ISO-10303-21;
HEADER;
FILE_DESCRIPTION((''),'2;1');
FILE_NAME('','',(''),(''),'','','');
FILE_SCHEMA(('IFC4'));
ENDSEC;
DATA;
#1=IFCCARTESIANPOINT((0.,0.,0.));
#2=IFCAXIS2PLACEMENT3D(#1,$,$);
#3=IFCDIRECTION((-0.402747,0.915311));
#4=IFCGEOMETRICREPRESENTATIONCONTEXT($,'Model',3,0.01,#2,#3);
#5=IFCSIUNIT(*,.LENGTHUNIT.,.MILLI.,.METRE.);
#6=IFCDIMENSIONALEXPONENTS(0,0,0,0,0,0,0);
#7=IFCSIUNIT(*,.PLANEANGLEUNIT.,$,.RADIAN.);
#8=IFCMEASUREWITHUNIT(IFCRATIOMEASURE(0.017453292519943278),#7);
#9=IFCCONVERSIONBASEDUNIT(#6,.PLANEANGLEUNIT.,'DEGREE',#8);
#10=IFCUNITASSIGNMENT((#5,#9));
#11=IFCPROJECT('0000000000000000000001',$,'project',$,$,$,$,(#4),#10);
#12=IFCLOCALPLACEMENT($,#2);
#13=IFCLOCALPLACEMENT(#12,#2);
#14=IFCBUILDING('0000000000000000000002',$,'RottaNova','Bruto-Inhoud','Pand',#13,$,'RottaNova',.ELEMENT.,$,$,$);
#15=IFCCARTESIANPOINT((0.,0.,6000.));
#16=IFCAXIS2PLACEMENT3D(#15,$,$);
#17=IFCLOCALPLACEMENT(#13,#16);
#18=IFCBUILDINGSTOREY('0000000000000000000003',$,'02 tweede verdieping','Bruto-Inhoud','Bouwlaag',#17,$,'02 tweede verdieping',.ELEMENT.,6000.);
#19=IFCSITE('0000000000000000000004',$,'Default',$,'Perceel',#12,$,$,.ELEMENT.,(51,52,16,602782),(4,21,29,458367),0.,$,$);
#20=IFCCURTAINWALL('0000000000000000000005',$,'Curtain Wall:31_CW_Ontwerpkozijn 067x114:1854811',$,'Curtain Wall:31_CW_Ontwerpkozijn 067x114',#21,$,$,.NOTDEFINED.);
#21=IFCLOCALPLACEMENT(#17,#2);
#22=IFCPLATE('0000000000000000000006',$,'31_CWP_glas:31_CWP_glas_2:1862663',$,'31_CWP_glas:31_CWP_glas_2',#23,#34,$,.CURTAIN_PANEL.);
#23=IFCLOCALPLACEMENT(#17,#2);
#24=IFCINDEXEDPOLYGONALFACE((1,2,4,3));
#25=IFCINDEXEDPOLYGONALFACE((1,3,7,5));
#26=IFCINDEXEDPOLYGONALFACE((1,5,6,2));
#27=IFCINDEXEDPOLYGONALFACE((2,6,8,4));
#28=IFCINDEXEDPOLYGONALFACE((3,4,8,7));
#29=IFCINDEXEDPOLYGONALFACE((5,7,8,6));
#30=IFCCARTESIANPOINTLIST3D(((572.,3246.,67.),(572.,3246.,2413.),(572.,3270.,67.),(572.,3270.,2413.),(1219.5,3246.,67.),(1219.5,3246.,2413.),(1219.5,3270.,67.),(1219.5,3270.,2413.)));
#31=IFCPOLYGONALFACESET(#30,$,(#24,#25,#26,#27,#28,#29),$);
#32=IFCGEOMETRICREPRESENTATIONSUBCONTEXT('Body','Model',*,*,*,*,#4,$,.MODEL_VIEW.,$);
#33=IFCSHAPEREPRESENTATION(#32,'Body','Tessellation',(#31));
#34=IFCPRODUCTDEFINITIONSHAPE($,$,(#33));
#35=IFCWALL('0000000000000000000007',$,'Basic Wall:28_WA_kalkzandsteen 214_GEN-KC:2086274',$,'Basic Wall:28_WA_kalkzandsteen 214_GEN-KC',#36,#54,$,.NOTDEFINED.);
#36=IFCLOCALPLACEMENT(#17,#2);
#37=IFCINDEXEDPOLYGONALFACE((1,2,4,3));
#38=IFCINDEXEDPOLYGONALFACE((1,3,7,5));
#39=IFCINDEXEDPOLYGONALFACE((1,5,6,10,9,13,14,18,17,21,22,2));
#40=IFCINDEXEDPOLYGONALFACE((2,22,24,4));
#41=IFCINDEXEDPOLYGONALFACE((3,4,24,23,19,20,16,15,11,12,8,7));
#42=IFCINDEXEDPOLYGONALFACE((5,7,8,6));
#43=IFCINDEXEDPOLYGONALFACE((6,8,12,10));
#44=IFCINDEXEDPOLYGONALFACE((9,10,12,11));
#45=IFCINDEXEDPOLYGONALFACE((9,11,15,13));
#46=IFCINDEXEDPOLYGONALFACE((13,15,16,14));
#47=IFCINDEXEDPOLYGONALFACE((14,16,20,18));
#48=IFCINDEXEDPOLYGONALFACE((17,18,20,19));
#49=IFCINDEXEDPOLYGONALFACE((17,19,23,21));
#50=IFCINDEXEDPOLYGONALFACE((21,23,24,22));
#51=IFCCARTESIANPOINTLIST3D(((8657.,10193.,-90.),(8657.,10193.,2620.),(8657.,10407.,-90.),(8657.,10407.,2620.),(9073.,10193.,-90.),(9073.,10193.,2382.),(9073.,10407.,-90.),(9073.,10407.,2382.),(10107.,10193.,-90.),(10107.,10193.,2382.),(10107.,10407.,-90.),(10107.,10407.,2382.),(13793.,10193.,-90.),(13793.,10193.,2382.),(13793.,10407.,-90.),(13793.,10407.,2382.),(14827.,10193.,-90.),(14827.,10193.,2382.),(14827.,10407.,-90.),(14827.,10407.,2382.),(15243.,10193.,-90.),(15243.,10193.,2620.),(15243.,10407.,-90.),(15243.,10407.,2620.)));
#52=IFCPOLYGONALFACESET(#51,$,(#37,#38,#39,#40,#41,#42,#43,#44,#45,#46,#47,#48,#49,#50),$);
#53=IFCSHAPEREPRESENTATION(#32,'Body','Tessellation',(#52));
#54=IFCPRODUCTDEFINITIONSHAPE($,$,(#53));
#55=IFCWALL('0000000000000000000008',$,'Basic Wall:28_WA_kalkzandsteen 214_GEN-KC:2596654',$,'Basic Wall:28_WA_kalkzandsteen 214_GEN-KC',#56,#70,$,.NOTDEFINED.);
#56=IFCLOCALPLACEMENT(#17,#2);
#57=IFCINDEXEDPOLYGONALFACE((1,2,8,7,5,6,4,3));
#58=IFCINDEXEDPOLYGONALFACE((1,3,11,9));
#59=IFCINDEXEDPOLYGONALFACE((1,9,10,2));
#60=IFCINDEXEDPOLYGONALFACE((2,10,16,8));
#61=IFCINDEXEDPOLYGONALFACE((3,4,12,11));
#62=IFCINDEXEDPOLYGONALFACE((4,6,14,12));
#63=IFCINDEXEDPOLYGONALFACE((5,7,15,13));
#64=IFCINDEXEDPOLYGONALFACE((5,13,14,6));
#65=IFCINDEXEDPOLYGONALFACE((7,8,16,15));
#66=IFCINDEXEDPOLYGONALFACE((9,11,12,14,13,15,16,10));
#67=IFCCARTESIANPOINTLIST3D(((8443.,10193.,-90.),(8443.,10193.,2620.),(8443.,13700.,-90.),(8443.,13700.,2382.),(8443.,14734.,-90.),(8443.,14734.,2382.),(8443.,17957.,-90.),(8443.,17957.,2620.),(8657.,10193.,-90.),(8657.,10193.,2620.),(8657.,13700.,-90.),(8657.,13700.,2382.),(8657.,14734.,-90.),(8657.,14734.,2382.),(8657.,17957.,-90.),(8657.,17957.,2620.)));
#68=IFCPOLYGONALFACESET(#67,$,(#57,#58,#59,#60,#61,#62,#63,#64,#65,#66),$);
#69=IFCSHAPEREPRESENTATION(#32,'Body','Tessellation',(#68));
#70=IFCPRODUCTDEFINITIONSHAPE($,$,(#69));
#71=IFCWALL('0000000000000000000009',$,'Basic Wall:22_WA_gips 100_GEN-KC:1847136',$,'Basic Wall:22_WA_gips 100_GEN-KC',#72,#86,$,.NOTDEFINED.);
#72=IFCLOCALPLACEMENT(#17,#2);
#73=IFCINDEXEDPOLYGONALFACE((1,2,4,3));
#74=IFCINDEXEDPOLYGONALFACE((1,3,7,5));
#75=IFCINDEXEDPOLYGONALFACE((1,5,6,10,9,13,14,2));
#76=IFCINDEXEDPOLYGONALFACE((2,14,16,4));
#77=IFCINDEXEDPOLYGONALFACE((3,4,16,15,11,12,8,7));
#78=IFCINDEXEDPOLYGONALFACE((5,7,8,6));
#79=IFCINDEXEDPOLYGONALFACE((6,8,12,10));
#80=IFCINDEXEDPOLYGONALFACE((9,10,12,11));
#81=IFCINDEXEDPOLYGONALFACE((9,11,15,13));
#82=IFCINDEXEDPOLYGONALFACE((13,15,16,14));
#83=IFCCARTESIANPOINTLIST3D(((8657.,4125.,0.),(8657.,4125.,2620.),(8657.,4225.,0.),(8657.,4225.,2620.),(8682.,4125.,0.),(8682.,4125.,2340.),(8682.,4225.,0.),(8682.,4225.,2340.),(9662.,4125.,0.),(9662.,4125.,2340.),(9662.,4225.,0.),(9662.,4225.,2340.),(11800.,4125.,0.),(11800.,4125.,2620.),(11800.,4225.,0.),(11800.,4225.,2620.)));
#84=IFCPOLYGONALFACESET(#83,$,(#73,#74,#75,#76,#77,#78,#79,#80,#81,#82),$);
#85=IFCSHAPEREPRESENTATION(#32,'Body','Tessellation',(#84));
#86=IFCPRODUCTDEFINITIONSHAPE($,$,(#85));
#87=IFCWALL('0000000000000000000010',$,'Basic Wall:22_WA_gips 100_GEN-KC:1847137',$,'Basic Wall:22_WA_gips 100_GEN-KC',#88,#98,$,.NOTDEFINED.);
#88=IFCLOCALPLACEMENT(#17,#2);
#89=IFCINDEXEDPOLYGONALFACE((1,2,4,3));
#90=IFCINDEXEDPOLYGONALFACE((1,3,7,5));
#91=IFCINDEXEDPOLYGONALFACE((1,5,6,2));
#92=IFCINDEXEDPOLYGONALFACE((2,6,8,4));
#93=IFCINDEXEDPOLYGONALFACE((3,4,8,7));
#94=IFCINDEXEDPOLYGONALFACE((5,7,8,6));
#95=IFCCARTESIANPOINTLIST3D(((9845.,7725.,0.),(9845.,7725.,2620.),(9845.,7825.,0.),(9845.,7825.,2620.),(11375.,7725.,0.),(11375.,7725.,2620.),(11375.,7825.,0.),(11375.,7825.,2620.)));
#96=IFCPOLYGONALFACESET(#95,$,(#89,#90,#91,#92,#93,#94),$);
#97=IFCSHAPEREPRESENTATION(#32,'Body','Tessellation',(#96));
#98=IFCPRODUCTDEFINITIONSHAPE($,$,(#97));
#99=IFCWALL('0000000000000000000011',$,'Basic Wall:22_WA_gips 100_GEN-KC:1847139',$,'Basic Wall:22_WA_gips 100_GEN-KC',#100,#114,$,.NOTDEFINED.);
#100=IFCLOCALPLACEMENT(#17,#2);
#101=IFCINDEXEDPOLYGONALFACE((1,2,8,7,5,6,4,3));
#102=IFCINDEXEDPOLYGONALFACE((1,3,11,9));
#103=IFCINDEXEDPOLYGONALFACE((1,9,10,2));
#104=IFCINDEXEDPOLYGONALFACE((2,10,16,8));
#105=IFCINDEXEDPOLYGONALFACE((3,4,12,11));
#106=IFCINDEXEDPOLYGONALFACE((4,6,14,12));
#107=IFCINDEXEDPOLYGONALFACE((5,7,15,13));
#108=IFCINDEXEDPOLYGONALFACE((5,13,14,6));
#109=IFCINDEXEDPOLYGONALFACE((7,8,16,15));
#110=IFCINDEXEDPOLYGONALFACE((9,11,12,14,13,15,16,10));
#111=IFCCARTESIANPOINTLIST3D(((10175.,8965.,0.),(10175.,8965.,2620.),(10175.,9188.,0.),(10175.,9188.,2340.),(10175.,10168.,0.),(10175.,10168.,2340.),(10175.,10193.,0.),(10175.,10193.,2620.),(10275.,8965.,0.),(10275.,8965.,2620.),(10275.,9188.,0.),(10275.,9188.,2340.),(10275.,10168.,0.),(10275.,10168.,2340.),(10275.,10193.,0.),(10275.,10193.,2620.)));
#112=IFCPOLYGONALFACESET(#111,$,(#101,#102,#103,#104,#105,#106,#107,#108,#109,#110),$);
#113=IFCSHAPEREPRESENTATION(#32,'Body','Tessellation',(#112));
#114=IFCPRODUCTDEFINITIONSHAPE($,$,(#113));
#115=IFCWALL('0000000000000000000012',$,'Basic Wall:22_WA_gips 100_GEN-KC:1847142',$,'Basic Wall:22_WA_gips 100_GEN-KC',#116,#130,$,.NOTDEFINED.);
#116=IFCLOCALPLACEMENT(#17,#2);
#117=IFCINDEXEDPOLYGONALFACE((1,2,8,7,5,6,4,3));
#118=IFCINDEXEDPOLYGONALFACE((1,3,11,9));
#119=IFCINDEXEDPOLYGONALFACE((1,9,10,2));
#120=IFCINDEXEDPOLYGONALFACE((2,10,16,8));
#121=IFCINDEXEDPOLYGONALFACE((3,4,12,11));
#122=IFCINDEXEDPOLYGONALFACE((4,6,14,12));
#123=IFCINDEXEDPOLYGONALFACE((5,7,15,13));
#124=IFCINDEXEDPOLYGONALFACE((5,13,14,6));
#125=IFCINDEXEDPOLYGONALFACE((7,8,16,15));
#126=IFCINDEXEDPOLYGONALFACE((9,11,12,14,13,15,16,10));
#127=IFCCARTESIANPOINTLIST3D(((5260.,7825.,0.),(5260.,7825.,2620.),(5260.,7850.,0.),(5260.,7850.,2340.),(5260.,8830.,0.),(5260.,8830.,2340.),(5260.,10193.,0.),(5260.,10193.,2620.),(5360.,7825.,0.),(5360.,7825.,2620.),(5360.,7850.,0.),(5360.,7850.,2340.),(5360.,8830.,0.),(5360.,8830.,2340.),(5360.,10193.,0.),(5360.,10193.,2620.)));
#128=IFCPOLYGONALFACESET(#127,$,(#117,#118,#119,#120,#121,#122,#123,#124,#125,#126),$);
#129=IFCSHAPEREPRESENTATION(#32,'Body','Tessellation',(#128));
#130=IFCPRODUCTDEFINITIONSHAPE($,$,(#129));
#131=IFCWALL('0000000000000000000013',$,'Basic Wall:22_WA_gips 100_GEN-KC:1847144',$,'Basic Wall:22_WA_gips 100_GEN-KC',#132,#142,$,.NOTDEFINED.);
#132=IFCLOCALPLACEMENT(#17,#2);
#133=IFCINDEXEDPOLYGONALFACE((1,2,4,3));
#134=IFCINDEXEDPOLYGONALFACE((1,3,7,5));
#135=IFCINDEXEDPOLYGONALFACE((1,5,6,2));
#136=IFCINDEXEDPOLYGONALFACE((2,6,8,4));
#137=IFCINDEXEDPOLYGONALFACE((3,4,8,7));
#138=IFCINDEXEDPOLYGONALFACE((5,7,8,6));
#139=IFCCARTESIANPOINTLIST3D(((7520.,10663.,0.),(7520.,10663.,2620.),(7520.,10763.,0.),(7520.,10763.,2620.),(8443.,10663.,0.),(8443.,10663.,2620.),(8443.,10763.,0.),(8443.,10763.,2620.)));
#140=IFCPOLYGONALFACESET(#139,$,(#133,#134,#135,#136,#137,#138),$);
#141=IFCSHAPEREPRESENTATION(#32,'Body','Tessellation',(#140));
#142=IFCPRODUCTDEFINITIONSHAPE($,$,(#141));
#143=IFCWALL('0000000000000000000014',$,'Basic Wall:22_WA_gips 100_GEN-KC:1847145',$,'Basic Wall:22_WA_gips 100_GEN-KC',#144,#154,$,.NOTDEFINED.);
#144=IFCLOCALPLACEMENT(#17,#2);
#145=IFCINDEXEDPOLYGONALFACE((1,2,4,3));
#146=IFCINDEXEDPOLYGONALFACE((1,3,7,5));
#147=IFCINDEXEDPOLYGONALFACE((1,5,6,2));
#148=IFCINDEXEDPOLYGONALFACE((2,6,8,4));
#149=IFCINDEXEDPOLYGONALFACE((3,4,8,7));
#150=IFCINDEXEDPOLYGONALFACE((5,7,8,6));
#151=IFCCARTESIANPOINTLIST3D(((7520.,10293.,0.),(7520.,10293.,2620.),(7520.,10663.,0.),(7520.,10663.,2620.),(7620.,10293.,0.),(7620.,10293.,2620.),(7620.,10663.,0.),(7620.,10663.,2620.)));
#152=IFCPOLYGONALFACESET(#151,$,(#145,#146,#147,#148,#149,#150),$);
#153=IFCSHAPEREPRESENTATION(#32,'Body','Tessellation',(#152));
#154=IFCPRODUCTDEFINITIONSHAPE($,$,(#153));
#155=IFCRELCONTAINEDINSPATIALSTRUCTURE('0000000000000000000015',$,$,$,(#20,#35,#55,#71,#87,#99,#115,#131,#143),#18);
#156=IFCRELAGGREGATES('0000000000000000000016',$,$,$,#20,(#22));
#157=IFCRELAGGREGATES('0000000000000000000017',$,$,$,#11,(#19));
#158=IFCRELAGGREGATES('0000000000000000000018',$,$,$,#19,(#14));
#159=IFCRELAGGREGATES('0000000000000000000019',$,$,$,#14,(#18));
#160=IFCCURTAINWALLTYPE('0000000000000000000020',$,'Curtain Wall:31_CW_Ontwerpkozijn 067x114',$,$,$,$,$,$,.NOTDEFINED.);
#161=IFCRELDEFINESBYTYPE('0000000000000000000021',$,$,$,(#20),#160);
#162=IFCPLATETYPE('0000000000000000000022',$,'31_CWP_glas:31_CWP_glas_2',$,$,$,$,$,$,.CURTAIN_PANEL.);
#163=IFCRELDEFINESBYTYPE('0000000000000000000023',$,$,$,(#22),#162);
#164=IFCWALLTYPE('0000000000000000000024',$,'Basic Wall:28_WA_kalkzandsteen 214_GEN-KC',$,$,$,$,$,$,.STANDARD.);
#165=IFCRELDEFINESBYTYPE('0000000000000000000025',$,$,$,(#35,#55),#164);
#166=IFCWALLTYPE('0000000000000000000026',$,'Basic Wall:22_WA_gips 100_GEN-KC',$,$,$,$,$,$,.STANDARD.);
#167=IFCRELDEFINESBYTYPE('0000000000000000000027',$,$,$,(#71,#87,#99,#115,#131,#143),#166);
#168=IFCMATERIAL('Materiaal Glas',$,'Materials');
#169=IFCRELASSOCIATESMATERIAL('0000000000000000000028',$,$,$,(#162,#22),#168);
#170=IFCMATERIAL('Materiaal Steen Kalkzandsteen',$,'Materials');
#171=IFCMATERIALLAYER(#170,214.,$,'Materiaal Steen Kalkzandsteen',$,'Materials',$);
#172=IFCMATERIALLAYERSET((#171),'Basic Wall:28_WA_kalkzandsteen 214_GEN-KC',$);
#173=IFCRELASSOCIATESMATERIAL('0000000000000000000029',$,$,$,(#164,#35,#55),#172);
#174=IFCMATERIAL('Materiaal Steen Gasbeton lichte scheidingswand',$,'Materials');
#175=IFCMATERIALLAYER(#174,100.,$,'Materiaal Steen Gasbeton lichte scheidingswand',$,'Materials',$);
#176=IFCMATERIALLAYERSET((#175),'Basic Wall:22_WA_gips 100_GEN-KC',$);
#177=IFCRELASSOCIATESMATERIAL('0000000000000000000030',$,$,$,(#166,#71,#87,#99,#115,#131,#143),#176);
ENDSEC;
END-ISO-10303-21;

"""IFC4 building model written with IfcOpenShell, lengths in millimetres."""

from ifc_helpers import new_model, entity, si_unit, converted_unit, direction, frame, frame_2d, origin, place, context, subcontext, project, spatial, rectangle, extrude, source, transform, mapped, material, layer, layer_set, type_object, type_shapes, element, aggregate, save


model = new_model("IFC4")

# Units and contexts
model_context = context("Model", 3, precision=0.01, world=origin(), true_north=direction((-0.402747, 0.915311)))
body_context = subcontext(model_context, "Body", "Model", "MODEL_VIEW")
ifc_project = project(units=[si_unit("LENGTHUNIT", "METRE", prefix="MILLI"), converted_unit("PLANEANGLEUNIT", "DEGREE", entity("IfcRatioMeasure", 0.017453292519943278), si_unit("PLANEANGLEUNIT", "RADIAN"), dimensions=[0, 0, 0, 0, 0, 0, 0])], contexts=[model_context])

# Site, building, storey
site_placement = place(None, origin())
site = spatial("IfcSite", under=ifc_project, at=site_placement, Name="Default", ObjectType="Perceel", CompositionType="ELEMENT", RefLatitude=(51, 52, 16, 602782), RefLongitude=(4, 21, 29, 458367), RefElevation=0.0)
building_placement = place(site_placement, origin())
building = spatial("IfcBuilding", under=site, at=building_placement, Name="RottaNova", Description="Bruto-Inhoud", ObjectType="Pand", LongName="RottaNova", CompositionType="ELEMENT")
storey_placement = place(building_placement, frame((0.0, 0.0, 6000.0)))
storey = spatial("IfcBuildingStorey", under=building, at=storey_placement, Name="02 tweede verdieping", Description="Bruto-Inhoud", ObjectType="Bouwlaag", LongName="02 tweede verdieping", CompositionType="ELEMENT", Elevation=6000.0)

# Shared definitions
curtain_wall_type = type_object("IfcCurtainWallType", Name="Curtain Wall:31_CW_Ontwerpkozijn 067x114", PredefinedType="NOTDEFINED")

# Curtain wall
curtain_wall_1_placement = place(storey_placement, frame((0.0, 0.0, -6000.0)))
curtain_wall_1 = element("IfcCurtainWall", 1, at=curtain_wall_1_placement, inside=storey, type_object=curtain_wall_type, Name="Curtain Wall:31_CW_Ontwerpkozijn 067x114:1854811", ObjectType="Curtain Wall:31_CW_Ontwerpkozijn 067x114", PredefinedType="NOTDEFINED")

# Plate
ifc_material_1 = material(Name="Materiaal Glas", Category="Materials")
plate_type_1 = type_object("IfcPlateType", Name="31_CWP_glas:31_CWP_glas_2", PredefinedType="CURTAIN_PANEL", material=ifc_material_1)
shared_shape_1 = source(origin(), body_context, "Body", "SweptSolid", [
    extrude(rectangle(XDim=24.0, YDim=647.5, at=frame_2d((0.0, 0.0), x_axis=(1.0, 0.0))), frame((323.8, 12.0, 0.0), z_axis=(0.0, 0.0, 1.0), x_axis=(0.0, 1.0, 0.0)), (0.0, 0.0, 1.0), 2346.0),
])
type_shapes(plate_type_1, [shared_shape_1])
plate_1_placement = place(curtain_wall_1_placement, frame((1219.5, 3270.0, 6067.0), z_axis=(0.0, 0.0, 1.0), x_axis=(-1.0, 0.0, 0.0)))
plate_1 = element("IfcPlate", 2, at=plate_1_placement, type_object=plate_type_1, material=ifc_material_1, Name="31_CWP_glas:31_CWP_glas_2:1862663", ObjectType="31_CWP_glas:31_CWP_glas_2", PredefinedType="CURTAIN_PANEL", context=body_context, shape_type="MappedRepresentation", body=[
    mapped(shared_shape_1, transform((0.0, 0.0, 0.0), scale=1.0)),
])
aggregate(curtain_wall_1, [plate_1])

# Wall, openings
ifc_material_2 = material(Name="Materiaal Steen Kalkzandsteen", Category="Materials")
ifc_layer_1 = layer(ifc_material_2, 214.0, Name="Materiaal Steen Kalkzandsteen", Category="Materials")
ifc_layer_set_1 = layer_set([ifc_layer_1], Name="Basic Wall:28_WA_kalkzandsteen 214_GEN-KC")
wall_type_1 = type_object("IfcWallType", Name="Basic Wall:28_WA_kalkzandsteen 214_GEN-KC", PredefinedType="STANDARD", material=ifc_layer_set_1)
wall_1_placement = place(storey_placement, frame((8657.0, 10300.0, -90.0)))
wall_1 = element("IfcWall", 3, at=wall_1_placement, inside=storey, type_object=wall_type_1, material=ifc_layer_set_1, Name="Basic Wall:28_WA_kalkzandsteen 214_GEN-KC:2086274", ObjectType="Basic Wall:28_WA_kalkzandsteen 214_GEN-KC", PredefinedType="NOTDEFINED", context=body_context, shape_type="SweptSolid", body=[
    extrude(rectangle(XDim=6586.0, YDim=214.0, at=frame_2d((3293.0, 0.0), x_axis=(-1.0, 0.0))), origin(), (0.0, 0.0, 1.0), 2710.0),
])
opening_1_placement = place(wall_1_placement, frame((5136.0, -107.0, 0.0)))
element("IfcOpeningElement", 4, at=opening_1_placement, cuts=wall_1, PredefinedType="OPENING", context=body_context, shape_type="SweptSolid", body=[
    extrude(rectangle(XDim=2472.0, YDim=1034.0, at=frame_2d((0.0, 0.0), x_axis=(1.0, 0.0))), frame((517.0, 0.0, 1236.0), z_axis=(0.0, 1.0, 0.0), x_axis=(0.0, 0.0, -1.0)), (0.0, 0.0, 1.0), 214.0),
])
opening_2_placement = place(wall_1_placement, frame((416.0, -107.0, 0.0)))
element("IfcOpeningElement", 5, at=opening_2_placement, cuts=wall_1, PredefinedType="OPENING", context=body_context, shape_type="SweptSolid", body=[
    extrude(rectangle(XDim=2472.0, YDim=1034.0, at=frame_2d((0.0, 0.0), x_axis=(1.0, 0.0))), frame((517.0, 0.0, 1236.0), z_axis=(0.0, 1.0, 0.0), x_axis=(0.0, 0.0, -1.0)), (0.0, 0.0, 1.0), 214.0),
])

# Walls, openings
wall_2_placement = place(storey_placement, frame((8550.0, 10193.0, -90.0), z_axis=(0.0, 0.0, 1.0), x_axis=(0.0, 1.0, 0.0)))
wall_2 = element("IfcWall", 6, at=wall_2_placement, inside=storey, type_object=wall_type_1, material=ifc_layer_set_1, Name="Basic Wall:28_WA_kalkzandsteen 214_GEN-KC:2596654", ObjectType="Basic Wall:28_WA_kalkzandsteen 214_GEN-KC", PredefinedType="NOTDEFINED", context=body_context, shape_type="SweptSolid", body=[
    extrude(rectangle(XDim=7764.0, YDim=214.0, at=frame_2d((3882.0, 0.0), x_axis=(1.0, 0.0))), origin(), (0.0, 0.0, 1.0), 2710.0),
])
opening_3_placement = place(wall_2_placement, frame((3507.0, 107.0, 0.0)))
element("IfcOpeningElement", 7, at=opening_3_placement, cuts=wall_2, PredefinedType="OPENING", context=body_context, shape_type="SweptSolid", body=[
    extrude(rectangle(XDim=2472.0, YDim=1034.0, at=frame_2d((0.0, 0.0), x_axis=(1.0, 0.0))), frame((517.0, -214.0, 1236.0), z_axis=(0.0, 1.0, 0.0), x_axis=(0.0, 0.0, -1.0)), (0.0, 0.0, 1.0), 214.0),
])
ifc_material_3 = material(Name="Materiaal Steen Gasbeton lichte scheidingswand", Category="Materials")
ifc_layer_2 = layer(ifc_material_3, 100.0, Name="Materiaal Steen Gasbeton lichte scheidingswand", Category="Materials")
ifc_layer_set_2 = layer_set([ifc_layer_2], Name="Basic Wall:22_WA_gips 100_GEN-KC")
wall_type_2 = type_object("IfcWallType", Name="Basic Wall:22_WA_gips 100_GEN-KC", PredefinedType="STANDARD", material=ifc_layer_set_2)
wall_3_placement = place(storey_placement, frame((8657.0, 4175.0, 0.0)))
wall_3 = element("IfcWall", 8, at=wall_3_placement, inside=storey, type_object=wall_type_2, material=ifc_layer_set_2, Name="Basic Wall:22_WA_gips 100_GEN-KC:1847136", ObjectType="Basic Wall:22_WA_gips 100_GEN-KC", PredefinedType="NOTDEFINED", context=body_context, shape_type="SweptSolid", body=[
    extrude(rectangle(XDim=3143.0, YDim=100.0, at=frame_2d((1571.5, 0.0), x_axis=(-1.0, 0.0))), origin(), (0.0, 0.0, 1.0), 2620.0),
])
opening_4_placement = place(wall_3_placement, frame((1005.0, 50.0, -90.0)))
element("IfcOpeningElement", 9, at=opening_4_placement, cuts=wall_3, PredefinedType="OPENING", context=body_context, shape_type="SweptSolid", body=[
    extrude(rectangle(XDim=2430.0, YDim=980.0, at=frame_2d((1215.0, 490.0), x_axis=(1.0, 0.0))), frame((0.0, 0.0, 0.0), z_axis=(0.0, -1.0, 0.0), x_axis=(0.0, 0.0, 1.0)), (0.0, 0.0, 1.0), 100.0),
])

# Wall
wall_4_placement = place(storey_placement, frame((9845.0, 7775.0, 0.0)))
element("IfcWall", 10, at=wall_4_placement, inside=storey, type_object=wall_type_2, material=ifc_layer_set_2, Name="Basic Wall:22_WA_gips 100_GEN-KC:1847137", ObjectType="Basic Wall:22_WA_gips 100_GEN-KC", PredefinedType="NOTDEFINED", context=body_context, shape_type="SweptSolid", body=[
    extrude(rectangle(XDim=1530.0, YDim=100.0, at=frame_2d((765.0, 0.0), x_axis=(-1.0, 0.0))), origin(), (0.0, 0.0, 1.0), 2620.0),
])

# Walls, openings
wall_5_placement = place(storey_placement, frame((10225.0, 8965.0, 0.0), z_axis=(0.0, 0.0, 1.0), x_axis=(0.0, 1.0, 0.0)))
wall_5 = element("IfcWall", 11, at=wall_5_placement, inside=storey, type_object=wall_type_2, material=ifc_layer_set_2, Name="Basic Wall:22_WA_gips 100_GEN-KC:1847139", ObjectType="Basic Wall:22_WA_gips 100_GEN-KC", PredefinedType="NOTDEFINED", context=body_context, shape_type="SweptSolid", body=[
    extrude(rectangle(XDim=1228.0, YDim=100.0, at=frame_2d((614.0, 0.0), x_axis=(1.0, 0.0))), origin(), (0.0, 0.0, 1.0), 2620.0),
])
opening_5_placement = place(wall_5_placement, frame((223.0, -50.0, -90.0)))
element("IfcOpeningElement", 12, at=opening_5_placement, cuts=wall_5, PredefinedType="OPENING", context=body_context, shape_type="SweptSolid", body=[
    extrude(rectangle(XDim=2430.0, YDim=980.0, at=frame_2d((1215.0, 490.0), x_axis=(1.0, 0.0))), frame((0.0, 0.0, 0.0), z_axis=(0.0, 1.0, 0.0), x_axis=(0.0, 0.0, 1.0)), (0.0, 0.0, 1.0), 100.0),
])
wall_6_placement = place(storey_placement, frame((5310.0, 10193.0, 0.0), z_axis=(0.0, 0.0, 1.0), x_axis=(0.0, -1.0, 0.0)))
wall_6 = element("IfcWall", 13, at=wall_6_placement, inside=storey, type_object=wall_type_2, material=ifc_layer_set_2, Name="Basic Wall:22_WA_gips 100_GEN-KC:1847142", ObjectType="Basic Wall:22_WA_gips 100_GEN-KC", PredefinedType="NOTDEFINED", context=body_context, shape_type="SweptSolid", body=[
    extrude(rectangle(XDim=2368.0, YDim=100.0, at=frame_2d((1184.0, 0.0), x_axis=(1.0, 0.0))), origin(), (0.0, 0.0, 1.0), 2620.0),
])
opening_6_placement = place(wall_6_placement, frame((2343.0, 50.0, -90.0)))
element("IfcOpeningElement", 14, at=opening_6_placement, cuts=wall_6, PredefinedType="OPENING", context=body_context, shape_type="SweptSolid", body=[
    extrude(rectangle(XDim=2430.0, YDim=980.0, at=frame_2d((1215.0, 490.0), x_axis=(1.0, 0.0))), frame((0.0, 0.0, 0.0), z_axis=(0.0, -1.0, 0.0), x_axis=(0.0, 0.0, 1.0)), (0.0, 0.0, 1.0), 100.0),
])

# Walls
wall_7_placement = place(storey_placement, frame((7520.0, 10713.0, 0.0)))
element("IfcWall", 15, at=wall_7_placement, inside=storey, type_object=wall_type_2, material=ifc_layer_set_2, Name="Basic Wall:22_WA_gips 100_GEN-KC:1847144", ObjectType="Basic Wall:22_WA_gips 100_GEN-KC", PredefinedType="NOTDEFINED", context=body_context, shape_type="SweptSolid", body=[
    extrude(rectangle(XDim=923.0, YDim=100.0, at=frame_2d((461.5, 0.0), x_axis=(-1.0, 0.0))), origin(), (0.0, 0.0, 1.0), 2620.0),
])
wall_8_placement = place(storey_placement, frame((7570.0, 10663.0, 0.0), z_axis=(0.0, 0.0, 1.0), x_axis=(0.0, -1.0, 0.0)))
element("IfcWall", 16, at=wall_8_placement, inside=storey, type_object=wall_type_2, material=ifc_layer_set_2, Name="Basic Wall:22_WA_gips 100_GEN-KC:1847145", ObjectType="Basic Wall:22_WA_gips 100_GEN-KC", PredefinedType="NOTDEFINED", context=body_context, shape_type="SweptSolid", body=[
    extrude(rectangle(XDim=370.0, YDim=100.0, at=frame_2d((185.0, 0.0), x_axis=(-1.0, 0.0))), origin(), (0.0, 0.0, 1.0), 2620.0),
])

save(model, "model.ifc")
